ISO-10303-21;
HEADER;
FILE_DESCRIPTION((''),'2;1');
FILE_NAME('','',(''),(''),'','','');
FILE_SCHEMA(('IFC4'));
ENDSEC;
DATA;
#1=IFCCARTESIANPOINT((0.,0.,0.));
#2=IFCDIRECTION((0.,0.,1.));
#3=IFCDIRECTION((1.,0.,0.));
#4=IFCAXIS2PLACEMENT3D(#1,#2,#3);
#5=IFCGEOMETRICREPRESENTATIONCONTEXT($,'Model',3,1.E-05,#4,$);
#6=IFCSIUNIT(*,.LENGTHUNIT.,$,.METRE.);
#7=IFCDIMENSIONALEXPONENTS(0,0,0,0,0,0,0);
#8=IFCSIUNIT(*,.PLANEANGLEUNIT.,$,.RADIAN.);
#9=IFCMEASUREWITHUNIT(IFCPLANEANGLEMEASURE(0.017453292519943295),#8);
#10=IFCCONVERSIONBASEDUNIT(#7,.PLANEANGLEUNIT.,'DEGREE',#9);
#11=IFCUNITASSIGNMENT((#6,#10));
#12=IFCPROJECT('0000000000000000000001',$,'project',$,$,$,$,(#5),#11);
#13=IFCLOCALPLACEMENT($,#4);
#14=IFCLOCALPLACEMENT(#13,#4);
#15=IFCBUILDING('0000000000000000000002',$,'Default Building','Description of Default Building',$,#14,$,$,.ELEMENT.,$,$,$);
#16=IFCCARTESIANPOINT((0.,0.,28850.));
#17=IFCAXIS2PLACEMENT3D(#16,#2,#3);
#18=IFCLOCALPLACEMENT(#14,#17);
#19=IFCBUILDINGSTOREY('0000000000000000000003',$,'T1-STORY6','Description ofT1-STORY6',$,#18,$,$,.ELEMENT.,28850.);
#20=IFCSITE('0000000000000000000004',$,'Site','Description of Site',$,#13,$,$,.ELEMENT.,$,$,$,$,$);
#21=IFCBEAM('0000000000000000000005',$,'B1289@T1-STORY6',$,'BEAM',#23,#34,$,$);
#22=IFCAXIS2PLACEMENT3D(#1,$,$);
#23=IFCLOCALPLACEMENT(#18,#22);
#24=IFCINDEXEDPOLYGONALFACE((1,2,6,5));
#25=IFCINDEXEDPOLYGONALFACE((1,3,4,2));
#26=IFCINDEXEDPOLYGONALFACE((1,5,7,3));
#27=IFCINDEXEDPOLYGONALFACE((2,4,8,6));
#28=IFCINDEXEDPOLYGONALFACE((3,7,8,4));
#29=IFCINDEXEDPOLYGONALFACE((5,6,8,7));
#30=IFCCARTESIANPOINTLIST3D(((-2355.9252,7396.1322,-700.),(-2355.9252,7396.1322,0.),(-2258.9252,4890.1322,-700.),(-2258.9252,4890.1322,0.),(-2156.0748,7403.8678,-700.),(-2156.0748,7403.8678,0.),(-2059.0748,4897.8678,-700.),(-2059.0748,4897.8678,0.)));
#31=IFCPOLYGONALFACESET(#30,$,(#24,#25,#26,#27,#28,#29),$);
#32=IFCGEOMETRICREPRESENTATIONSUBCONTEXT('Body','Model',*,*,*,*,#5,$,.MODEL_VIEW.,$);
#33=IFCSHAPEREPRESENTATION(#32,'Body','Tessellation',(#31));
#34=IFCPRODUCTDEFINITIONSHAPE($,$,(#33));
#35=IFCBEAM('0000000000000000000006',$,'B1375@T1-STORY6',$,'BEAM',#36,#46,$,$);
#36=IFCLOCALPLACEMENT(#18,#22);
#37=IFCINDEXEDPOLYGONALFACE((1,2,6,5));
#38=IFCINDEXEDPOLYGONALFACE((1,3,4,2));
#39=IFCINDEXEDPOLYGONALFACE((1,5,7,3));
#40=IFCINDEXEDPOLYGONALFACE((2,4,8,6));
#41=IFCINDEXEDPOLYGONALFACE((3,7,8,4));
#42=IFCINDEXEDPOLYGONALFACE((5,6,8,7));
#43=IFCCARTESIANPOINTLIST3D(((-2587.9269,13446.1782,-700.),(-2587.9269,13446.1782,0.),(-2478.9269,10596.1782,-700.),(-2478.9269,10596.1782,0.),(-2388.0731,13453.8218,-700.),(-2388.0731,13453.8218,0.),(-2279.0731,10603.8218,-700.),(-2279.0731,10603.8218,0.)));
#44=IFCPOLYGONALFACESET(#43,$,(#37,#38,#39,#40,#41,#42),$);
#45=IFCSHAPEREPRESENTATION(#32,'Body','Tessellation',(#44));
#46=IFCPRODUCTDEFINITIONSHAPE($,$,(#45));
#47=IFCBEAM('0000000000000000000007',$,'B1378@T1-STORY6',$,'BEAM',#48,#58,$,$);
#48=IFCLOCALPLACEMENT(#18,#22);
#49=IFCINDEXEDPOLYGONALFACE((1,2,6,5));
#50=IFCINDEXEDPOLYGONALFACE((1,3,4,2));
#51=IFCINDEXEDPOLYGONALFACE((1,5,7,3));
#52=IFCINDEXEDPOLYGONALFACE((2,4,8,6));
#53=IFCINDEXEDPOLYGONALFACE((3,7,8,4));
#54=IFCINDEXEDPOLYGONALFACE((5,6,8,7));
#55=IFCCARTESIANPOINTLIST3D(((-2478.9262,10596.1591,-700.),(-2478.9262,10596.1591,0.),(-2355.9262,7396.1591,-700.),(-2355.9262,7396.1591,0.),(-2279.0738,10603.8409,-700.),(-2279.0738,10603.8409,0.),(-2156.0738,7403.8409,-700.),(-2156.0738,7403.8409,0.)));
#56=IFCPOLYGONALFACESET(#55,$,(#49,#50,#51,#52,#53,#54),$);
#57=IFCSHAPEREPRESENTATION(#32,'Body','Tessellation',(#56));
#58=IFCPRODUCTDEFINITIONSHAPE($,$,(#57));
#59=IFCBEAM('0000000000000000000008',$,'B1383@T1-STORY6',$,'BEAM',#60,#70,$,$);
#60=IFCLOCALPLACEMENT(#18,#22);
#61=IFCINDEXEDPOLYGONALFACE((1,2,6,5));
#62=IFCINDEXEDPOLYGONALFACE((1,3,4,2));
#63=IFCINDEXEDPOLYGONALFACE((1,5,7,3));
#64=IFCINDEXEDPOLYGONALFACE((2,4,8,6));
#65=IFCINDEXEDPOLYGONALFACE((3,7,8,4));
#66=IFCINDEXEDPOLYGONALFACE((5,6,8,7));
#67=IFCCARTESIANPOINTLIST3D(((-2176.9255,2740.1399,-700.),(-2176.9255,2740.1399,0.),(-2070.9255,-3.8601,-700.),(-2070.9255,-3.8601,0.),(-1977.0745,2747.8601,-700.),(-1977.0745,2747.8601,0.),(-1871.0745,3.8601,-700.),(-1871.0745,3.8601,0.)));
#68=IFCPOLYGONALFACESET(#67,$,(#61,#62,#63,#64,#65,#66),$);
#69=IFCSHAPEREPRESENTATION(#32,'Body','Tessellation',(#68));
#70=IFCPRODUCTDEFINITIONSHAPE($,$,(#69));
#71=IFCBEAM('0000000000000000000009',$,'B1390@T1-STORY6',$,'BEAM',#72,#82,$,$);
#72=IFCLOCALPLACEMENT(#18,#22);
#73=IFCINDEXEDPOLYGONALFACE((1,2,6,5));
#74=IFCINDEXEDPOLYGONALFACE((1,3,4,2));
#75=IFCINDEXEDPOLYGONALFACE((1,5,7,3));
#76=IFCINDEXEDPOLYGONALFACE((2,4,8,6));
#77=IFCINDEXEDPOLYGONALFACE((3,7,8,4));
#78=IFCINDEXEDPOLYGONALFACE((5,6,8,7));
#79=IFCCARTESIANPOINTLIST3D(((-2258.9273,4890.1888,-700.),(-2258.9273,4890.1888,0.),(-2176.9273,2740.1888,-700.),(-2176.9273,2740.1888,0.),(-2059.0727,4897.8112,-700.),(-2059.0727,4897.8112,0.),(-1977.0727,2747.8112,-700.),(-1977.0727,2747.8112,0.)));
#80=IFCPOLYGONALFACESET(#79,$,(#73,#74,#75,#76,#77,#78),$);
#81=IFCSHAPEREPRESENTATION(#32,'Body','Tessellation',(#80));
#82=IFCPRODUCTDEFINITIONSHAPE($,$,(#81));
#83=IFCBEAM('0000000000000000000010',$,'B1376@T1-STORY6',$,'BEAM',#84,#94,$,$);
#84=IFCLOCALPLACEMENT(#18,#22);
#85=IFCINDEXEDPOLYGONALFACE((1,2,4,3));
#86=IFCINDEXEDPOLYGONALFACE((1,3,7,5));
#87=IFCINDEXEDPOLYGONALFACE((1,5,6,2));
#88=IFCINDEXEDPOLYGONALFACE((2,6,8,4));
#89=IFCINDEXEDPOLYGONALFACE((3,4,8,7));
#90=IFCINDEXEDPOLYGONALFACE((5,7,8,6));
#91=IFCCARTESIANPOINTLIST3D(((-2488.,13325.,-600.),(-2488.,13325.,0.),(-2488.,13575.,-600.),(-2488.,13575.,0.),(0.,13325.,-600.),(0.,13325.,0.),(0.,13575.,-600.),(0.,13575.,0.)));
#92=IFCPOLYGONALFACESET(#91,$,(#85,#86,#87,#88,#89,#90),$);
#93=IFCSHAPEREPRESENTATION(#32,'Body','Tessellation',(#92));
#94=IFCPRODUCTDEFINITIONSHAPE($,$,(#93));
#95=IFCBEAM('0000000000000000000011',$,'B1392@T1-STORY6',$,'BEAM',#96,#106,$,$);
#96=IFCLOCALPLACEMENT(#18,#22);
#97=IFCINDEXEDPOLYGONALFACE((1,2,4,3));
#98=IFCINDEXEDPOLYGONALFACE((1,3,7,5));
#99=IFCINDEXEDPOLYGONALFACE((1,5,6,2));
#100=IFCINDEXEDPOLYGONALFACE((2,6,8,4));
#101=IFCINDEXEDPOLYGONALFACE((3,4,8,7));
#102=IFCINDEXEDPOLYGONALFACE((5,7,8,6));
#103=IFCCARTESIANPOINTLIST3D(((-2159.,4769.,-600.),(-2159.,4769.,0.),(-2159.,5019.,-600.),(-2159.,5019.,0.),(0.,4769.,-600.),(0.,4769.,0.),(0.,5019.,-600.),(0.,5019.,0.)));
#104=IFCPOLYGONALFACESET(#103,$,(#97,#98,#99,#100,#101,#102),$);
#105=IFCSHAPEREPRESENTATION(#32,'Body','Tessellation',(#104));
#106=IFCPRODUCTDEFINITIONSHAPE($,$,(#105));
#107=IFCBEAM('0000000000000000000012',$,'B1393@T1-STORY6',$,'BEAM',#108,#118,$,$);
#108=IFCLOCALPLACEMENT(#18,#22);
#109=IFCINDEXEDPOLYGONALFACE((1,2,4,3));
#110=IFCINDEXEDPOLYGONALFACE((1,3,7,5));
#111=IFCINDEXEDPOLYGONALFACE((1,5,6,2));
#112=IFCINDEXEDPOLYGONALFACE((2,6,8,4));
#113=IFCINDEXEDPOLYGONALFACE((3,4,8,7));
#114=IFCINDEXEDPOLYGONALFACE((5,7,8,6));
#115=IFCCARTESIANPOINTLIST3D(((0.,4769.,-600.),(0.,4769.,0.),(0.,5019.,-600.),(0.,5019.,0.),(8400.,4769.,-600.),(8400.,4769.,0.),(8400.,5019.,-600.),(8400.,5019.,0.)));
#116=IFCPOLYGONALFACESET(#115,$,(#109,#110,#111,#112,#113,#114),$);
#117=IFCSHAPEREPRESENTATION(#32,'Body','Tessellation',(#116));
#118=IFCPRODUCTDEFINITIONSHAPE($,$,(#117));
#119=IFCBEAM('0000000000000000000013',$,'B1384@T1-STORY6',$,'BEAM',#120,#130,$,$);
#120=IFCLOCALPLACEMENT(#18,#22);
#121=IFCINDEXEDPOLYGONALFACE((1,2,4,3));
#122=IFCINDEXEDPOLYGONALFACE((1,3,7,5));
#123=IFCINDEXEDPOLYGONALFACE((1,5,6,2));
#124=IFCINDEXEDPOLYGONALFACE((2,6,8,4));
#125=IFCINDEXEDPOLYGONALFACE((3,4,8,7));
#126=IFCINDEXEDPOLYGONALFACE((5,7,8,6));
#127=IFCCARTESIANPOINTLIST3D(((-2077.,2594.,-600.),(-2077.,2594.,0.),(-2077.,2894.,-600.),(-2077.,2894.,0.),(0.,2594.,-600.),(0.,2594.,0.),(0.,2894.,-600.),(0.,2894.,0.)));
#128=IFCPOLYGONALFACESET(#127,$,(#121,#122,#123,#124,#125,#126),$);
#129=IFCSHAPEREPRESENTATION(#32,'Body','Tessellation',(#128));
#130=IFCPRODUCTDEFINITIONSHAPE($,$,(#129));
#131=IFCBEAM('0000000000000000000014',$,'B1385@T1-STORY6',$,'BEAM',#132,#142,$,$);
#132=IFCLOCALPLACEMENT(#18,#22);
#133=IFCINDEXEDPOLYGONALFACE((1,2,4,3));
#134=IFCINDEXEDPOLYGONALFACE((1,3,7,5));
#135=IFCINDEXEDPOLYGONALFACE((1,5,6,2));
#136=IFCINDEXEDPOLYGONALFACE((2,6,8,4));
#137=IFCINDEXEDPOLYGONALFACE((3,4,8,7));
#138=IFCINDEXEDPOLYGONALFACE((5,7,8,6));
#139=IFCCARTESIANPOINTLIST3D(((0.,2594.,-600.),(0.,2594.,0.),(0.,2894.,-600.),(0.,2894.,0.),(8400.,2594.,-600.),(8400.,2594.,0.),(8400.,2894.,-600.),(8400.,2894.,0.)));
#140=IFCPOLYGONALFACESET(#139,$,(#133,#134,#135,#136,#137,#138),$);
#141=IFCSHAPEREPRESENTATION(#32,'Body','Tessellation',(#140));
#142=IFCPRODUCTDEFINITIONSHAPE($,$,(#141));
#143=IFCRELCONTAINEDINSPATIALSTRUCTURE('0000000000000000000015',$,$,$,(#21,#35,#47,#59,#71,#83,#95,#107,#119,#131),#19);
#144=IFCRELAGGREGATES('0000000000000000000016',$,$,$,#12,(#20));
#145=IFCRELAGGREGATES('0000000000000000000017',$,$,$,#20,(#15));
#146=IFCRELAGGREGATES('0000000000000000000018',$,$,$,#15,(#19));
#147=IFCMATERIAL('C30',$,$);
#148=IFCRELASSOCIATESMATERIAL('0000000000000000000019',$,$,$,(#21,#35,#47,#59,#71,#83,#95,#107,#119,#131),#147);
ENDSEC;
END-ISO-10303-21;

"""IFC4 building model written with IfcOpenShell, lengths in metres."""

from ifc_helpers import new_model, entity, si_unit, converted_unit, frame, origin_with_axes, place, context, subcontext, project, spatial, rectangle, extrude, material, element, save


model = new_model("IFC4")

# Units and contexts
model_context = context("Model", 3, precision=1e-05, world=origin_with_axes())
body_context = subcontext(model_context, "Body", "Model", "MODEL_VIEW")
ifc_project = project(units=[si_unit("LENGTHUNIT", "METRE"), converted_unit("PLANEANGLEUNIT", "DEGREE", entity("IfcPlaneAngleMeasure", 0.017453292519943295), si_unit("PLANEANGLEUNIT", "RADIAN"), dimensions=[0, 0, 0, 0, 0, 0, 0])], contexts=[model_context])

# Site, building, storey
site_placement = place(None, origin_with_axes())
site = spatial("IfcSite", under=ifc_project, at=site_placement, Name="Site", Description="Description of Site", CompositionType="ELEMENT")
building_placement = place(site_placement, origin_with_axes())
building = spatial("IfcBuilding", under=site, at=building_placement, Name="Default Building", Description="Description of Default Building", CompositionType="ELEMENT")
storey_placement = place(building_placement, frame((0.0, 0.0, 28850.0), z_axis=(0.0, 0.0, 1.0), x_axis=(1.0, 0.0, 0.0)))
storey = spatial("IfcBuildingStorey", under=building, at=storey_placement, Name="T1-STORY6", Description="Description ofT1-STORY6", CompositionType="ELEMENT", Elevation=28850.0)

# Beams
ifc_material_1 = material(Name="C30")
beam_1_placement = place(storey_placement, frame((-2256.0, 7400.0, -350.0), z_axis=(0.038678, -0.999252, 0.0), x_axis=(0.999252, 0.038678, 0.0)))
element("IfcBeam", 1, at=beam_1_placement, inside=storey, material=ifc_material_1, Name="B1289@T1-STORY6", ObjectType="BEAM", context=body_context, shape_type="SweptSolid", body=[
    extrude(rectangle(XDim=200.0, YDim=700.0), origin_with_axes(), (0.0, 0.0, 1.0), 2507.8766),
])
beam_2_placement = place(storey_placement, frame((-2488.0, 13450.0, -350.0), z_axis=(0.038218, -0.999269, 0.0), x_axis=(0.999269, 0.038218, 0.0)))
element("IfcBeam", 2, at=beam_2_placement, inside=storey, material=ifc_material_1, Name="B1375@T1-STORY6", ObjectType="BEAM", context=body_context, shape_type="SweptSolid", body=[
    extrude(rectangle(XDim=200.0, YDim=700.0), origin_with_axes(), (0.0, 0.0, 1.0), 2852.0836),
])
beam_3_placement = place(storey_placement, frame((-2379.0, 10600.0, -350.0), z_axis=(0.038409, -0.999262, 0.0), x_axis=(0.999262, 0.038409, 0.0)))
element("IfcBeam", 3, at=beam_3_placement, inside=storey, material=ifc_material_1, Name="B1378@T1-STORY6", ObjectType="BEAM", context=body_context, shape_type="SweptSolid", body=[
    extrude(rectangle(XDim=200.0, YDim=700.0), origin_with_axes(), (0.0, 0.0, 1.0), 3202.363),
])
beam_4_placement = place(storey_placement, frame((-2077.0, 2744.0, -350.0), z_axis=(0.038601, -0.999255, 0.0), x_axis=(0.999255, 0.038601, 0.0)))
element("IfcBeam", 4, at=beam_4_placement, inside=storey, material=ifc_material_1, Name="B1383@T1-STORY6", ObjectType="BEAM", context=body_context, shape_type="SweptSolid", body=[
    extrude(rectangle(XDim=200.0, YDim=700.0), origin_with_axes(), (0.0, 0.0, 1.0), 2746.0466),
])
beam_5_placement = place(storey_placement, frame((-2159.0, 4894.0, -350.0), z_axis=(0.038112, -0.999273, 0.0), x_axis=(0.999273, 0.038112, 0.0)))
element("IfcBeam", 5, at=beam_5_placement, inside=storey, material=ifc_material_1, Name="B1390@T1-STORY6", ObjectType="BEAM", context=body_context, shape_type="SweptSolid", body=[
    extrude(rectangle(XDim=200.0, YDim=700.0), origin_with_axes(), (0.0, 0.0, 1.0), 2151.5632),
])
beam_6_placement = place(storey_placement, frame((-2488.0, 13450.0, -300.0), z_axis=(1.0, 0.0, 0.0), x_axis=(0.0, 1.0, 0.0)))
element("IfcBeam", 6, at=beam_6_placement, inside=storey, material=ifc_material_1, Name="B1376@T1-STORY6", ObjectType="BEAM", context=body_context, shape_type="SweptSolid", body=[
    extrude(rectangle(XDim=250.0, YDim=600.0), origin_with_axes(), (0.0, 0.0, 1.0), 2488.0),
])
beam_7_placement = place(storey_placement, frame((-2159.0, 4894.0, -300.0), z_axis=(1.0, 0.0, 0.0), x_axis=(0.0, 1.0, 0.0)))
element("IfcBeam", 7, at=beam_7_placement, inside=storey, material=ifc_material_1, Name="B1392@T1-STORY6", ObjectType="BEAM", context=body_context, shape_type="SweptSolid", body=[
    extrude(rectangle(XDim=250.0, YDim=600.0), origin_with_axes(), (0.0, 0.0, 1.0), 2159.0),
])
beam_8_placement = place(storey_placement, frame((0.0, 4894.0, -300.0), z_axis=(1.0, 0.0, 0.0), x_axis=(0.0, 1.0, 0.0)))
element("IfcBeam", 8, at=beam_8_placement, inside=storey, material=ifc_material_1, Name="B1393@T1-STORY6", ObjectType="BEAM", context=body_context, shape_type="SweptSolid", body=[
    extrude(rectangle(XDim=250.0, YDim=600.0), origin_with_axes(), (0.0, 0.0, 1.0), 8400.0),
])
beam_9_placement = place(storey_placement, frame((-2077.0, 2744.0, -300.0), z_axis=(1.0, 0.0, 0.0), x_axis=(0.0, 1.0, 0.0)))
element("IfcBeam", 9, at=beam_9_placement, inside=storey, material=ifc_material_1, Name="B1384@T1-STORY6", ObjectType="BEAM", context=body_context, shape_type="SweptSolid", body=[
    extrude(rectangle(XDim=300.0, YDim=600.0), origin_with_axes(), (0.0, 0.0, 1.0), 2077.0),
])
beam_10_placement = place(storey_placement, frame((0.0, 2744.0, -300.0), z_axis=(1.0, 0.0, 0.0), x_axis=(0.0, 1.0, 0.0)))
element("IfcBeam", 10, at=beam_10_placement, inside=storey, material=ifc_material_1, Name="B1385@T1-STORY6", ObjectType="BEAM", context=body_context, shape_type="SweptSolid", body=[
    extrude(rectangle(XDim=300.0, YDim=600.0), origin_with_axes(), (0.0, 0.0, 1.0), 8400.0),
])

save(model, "model.ifc")
